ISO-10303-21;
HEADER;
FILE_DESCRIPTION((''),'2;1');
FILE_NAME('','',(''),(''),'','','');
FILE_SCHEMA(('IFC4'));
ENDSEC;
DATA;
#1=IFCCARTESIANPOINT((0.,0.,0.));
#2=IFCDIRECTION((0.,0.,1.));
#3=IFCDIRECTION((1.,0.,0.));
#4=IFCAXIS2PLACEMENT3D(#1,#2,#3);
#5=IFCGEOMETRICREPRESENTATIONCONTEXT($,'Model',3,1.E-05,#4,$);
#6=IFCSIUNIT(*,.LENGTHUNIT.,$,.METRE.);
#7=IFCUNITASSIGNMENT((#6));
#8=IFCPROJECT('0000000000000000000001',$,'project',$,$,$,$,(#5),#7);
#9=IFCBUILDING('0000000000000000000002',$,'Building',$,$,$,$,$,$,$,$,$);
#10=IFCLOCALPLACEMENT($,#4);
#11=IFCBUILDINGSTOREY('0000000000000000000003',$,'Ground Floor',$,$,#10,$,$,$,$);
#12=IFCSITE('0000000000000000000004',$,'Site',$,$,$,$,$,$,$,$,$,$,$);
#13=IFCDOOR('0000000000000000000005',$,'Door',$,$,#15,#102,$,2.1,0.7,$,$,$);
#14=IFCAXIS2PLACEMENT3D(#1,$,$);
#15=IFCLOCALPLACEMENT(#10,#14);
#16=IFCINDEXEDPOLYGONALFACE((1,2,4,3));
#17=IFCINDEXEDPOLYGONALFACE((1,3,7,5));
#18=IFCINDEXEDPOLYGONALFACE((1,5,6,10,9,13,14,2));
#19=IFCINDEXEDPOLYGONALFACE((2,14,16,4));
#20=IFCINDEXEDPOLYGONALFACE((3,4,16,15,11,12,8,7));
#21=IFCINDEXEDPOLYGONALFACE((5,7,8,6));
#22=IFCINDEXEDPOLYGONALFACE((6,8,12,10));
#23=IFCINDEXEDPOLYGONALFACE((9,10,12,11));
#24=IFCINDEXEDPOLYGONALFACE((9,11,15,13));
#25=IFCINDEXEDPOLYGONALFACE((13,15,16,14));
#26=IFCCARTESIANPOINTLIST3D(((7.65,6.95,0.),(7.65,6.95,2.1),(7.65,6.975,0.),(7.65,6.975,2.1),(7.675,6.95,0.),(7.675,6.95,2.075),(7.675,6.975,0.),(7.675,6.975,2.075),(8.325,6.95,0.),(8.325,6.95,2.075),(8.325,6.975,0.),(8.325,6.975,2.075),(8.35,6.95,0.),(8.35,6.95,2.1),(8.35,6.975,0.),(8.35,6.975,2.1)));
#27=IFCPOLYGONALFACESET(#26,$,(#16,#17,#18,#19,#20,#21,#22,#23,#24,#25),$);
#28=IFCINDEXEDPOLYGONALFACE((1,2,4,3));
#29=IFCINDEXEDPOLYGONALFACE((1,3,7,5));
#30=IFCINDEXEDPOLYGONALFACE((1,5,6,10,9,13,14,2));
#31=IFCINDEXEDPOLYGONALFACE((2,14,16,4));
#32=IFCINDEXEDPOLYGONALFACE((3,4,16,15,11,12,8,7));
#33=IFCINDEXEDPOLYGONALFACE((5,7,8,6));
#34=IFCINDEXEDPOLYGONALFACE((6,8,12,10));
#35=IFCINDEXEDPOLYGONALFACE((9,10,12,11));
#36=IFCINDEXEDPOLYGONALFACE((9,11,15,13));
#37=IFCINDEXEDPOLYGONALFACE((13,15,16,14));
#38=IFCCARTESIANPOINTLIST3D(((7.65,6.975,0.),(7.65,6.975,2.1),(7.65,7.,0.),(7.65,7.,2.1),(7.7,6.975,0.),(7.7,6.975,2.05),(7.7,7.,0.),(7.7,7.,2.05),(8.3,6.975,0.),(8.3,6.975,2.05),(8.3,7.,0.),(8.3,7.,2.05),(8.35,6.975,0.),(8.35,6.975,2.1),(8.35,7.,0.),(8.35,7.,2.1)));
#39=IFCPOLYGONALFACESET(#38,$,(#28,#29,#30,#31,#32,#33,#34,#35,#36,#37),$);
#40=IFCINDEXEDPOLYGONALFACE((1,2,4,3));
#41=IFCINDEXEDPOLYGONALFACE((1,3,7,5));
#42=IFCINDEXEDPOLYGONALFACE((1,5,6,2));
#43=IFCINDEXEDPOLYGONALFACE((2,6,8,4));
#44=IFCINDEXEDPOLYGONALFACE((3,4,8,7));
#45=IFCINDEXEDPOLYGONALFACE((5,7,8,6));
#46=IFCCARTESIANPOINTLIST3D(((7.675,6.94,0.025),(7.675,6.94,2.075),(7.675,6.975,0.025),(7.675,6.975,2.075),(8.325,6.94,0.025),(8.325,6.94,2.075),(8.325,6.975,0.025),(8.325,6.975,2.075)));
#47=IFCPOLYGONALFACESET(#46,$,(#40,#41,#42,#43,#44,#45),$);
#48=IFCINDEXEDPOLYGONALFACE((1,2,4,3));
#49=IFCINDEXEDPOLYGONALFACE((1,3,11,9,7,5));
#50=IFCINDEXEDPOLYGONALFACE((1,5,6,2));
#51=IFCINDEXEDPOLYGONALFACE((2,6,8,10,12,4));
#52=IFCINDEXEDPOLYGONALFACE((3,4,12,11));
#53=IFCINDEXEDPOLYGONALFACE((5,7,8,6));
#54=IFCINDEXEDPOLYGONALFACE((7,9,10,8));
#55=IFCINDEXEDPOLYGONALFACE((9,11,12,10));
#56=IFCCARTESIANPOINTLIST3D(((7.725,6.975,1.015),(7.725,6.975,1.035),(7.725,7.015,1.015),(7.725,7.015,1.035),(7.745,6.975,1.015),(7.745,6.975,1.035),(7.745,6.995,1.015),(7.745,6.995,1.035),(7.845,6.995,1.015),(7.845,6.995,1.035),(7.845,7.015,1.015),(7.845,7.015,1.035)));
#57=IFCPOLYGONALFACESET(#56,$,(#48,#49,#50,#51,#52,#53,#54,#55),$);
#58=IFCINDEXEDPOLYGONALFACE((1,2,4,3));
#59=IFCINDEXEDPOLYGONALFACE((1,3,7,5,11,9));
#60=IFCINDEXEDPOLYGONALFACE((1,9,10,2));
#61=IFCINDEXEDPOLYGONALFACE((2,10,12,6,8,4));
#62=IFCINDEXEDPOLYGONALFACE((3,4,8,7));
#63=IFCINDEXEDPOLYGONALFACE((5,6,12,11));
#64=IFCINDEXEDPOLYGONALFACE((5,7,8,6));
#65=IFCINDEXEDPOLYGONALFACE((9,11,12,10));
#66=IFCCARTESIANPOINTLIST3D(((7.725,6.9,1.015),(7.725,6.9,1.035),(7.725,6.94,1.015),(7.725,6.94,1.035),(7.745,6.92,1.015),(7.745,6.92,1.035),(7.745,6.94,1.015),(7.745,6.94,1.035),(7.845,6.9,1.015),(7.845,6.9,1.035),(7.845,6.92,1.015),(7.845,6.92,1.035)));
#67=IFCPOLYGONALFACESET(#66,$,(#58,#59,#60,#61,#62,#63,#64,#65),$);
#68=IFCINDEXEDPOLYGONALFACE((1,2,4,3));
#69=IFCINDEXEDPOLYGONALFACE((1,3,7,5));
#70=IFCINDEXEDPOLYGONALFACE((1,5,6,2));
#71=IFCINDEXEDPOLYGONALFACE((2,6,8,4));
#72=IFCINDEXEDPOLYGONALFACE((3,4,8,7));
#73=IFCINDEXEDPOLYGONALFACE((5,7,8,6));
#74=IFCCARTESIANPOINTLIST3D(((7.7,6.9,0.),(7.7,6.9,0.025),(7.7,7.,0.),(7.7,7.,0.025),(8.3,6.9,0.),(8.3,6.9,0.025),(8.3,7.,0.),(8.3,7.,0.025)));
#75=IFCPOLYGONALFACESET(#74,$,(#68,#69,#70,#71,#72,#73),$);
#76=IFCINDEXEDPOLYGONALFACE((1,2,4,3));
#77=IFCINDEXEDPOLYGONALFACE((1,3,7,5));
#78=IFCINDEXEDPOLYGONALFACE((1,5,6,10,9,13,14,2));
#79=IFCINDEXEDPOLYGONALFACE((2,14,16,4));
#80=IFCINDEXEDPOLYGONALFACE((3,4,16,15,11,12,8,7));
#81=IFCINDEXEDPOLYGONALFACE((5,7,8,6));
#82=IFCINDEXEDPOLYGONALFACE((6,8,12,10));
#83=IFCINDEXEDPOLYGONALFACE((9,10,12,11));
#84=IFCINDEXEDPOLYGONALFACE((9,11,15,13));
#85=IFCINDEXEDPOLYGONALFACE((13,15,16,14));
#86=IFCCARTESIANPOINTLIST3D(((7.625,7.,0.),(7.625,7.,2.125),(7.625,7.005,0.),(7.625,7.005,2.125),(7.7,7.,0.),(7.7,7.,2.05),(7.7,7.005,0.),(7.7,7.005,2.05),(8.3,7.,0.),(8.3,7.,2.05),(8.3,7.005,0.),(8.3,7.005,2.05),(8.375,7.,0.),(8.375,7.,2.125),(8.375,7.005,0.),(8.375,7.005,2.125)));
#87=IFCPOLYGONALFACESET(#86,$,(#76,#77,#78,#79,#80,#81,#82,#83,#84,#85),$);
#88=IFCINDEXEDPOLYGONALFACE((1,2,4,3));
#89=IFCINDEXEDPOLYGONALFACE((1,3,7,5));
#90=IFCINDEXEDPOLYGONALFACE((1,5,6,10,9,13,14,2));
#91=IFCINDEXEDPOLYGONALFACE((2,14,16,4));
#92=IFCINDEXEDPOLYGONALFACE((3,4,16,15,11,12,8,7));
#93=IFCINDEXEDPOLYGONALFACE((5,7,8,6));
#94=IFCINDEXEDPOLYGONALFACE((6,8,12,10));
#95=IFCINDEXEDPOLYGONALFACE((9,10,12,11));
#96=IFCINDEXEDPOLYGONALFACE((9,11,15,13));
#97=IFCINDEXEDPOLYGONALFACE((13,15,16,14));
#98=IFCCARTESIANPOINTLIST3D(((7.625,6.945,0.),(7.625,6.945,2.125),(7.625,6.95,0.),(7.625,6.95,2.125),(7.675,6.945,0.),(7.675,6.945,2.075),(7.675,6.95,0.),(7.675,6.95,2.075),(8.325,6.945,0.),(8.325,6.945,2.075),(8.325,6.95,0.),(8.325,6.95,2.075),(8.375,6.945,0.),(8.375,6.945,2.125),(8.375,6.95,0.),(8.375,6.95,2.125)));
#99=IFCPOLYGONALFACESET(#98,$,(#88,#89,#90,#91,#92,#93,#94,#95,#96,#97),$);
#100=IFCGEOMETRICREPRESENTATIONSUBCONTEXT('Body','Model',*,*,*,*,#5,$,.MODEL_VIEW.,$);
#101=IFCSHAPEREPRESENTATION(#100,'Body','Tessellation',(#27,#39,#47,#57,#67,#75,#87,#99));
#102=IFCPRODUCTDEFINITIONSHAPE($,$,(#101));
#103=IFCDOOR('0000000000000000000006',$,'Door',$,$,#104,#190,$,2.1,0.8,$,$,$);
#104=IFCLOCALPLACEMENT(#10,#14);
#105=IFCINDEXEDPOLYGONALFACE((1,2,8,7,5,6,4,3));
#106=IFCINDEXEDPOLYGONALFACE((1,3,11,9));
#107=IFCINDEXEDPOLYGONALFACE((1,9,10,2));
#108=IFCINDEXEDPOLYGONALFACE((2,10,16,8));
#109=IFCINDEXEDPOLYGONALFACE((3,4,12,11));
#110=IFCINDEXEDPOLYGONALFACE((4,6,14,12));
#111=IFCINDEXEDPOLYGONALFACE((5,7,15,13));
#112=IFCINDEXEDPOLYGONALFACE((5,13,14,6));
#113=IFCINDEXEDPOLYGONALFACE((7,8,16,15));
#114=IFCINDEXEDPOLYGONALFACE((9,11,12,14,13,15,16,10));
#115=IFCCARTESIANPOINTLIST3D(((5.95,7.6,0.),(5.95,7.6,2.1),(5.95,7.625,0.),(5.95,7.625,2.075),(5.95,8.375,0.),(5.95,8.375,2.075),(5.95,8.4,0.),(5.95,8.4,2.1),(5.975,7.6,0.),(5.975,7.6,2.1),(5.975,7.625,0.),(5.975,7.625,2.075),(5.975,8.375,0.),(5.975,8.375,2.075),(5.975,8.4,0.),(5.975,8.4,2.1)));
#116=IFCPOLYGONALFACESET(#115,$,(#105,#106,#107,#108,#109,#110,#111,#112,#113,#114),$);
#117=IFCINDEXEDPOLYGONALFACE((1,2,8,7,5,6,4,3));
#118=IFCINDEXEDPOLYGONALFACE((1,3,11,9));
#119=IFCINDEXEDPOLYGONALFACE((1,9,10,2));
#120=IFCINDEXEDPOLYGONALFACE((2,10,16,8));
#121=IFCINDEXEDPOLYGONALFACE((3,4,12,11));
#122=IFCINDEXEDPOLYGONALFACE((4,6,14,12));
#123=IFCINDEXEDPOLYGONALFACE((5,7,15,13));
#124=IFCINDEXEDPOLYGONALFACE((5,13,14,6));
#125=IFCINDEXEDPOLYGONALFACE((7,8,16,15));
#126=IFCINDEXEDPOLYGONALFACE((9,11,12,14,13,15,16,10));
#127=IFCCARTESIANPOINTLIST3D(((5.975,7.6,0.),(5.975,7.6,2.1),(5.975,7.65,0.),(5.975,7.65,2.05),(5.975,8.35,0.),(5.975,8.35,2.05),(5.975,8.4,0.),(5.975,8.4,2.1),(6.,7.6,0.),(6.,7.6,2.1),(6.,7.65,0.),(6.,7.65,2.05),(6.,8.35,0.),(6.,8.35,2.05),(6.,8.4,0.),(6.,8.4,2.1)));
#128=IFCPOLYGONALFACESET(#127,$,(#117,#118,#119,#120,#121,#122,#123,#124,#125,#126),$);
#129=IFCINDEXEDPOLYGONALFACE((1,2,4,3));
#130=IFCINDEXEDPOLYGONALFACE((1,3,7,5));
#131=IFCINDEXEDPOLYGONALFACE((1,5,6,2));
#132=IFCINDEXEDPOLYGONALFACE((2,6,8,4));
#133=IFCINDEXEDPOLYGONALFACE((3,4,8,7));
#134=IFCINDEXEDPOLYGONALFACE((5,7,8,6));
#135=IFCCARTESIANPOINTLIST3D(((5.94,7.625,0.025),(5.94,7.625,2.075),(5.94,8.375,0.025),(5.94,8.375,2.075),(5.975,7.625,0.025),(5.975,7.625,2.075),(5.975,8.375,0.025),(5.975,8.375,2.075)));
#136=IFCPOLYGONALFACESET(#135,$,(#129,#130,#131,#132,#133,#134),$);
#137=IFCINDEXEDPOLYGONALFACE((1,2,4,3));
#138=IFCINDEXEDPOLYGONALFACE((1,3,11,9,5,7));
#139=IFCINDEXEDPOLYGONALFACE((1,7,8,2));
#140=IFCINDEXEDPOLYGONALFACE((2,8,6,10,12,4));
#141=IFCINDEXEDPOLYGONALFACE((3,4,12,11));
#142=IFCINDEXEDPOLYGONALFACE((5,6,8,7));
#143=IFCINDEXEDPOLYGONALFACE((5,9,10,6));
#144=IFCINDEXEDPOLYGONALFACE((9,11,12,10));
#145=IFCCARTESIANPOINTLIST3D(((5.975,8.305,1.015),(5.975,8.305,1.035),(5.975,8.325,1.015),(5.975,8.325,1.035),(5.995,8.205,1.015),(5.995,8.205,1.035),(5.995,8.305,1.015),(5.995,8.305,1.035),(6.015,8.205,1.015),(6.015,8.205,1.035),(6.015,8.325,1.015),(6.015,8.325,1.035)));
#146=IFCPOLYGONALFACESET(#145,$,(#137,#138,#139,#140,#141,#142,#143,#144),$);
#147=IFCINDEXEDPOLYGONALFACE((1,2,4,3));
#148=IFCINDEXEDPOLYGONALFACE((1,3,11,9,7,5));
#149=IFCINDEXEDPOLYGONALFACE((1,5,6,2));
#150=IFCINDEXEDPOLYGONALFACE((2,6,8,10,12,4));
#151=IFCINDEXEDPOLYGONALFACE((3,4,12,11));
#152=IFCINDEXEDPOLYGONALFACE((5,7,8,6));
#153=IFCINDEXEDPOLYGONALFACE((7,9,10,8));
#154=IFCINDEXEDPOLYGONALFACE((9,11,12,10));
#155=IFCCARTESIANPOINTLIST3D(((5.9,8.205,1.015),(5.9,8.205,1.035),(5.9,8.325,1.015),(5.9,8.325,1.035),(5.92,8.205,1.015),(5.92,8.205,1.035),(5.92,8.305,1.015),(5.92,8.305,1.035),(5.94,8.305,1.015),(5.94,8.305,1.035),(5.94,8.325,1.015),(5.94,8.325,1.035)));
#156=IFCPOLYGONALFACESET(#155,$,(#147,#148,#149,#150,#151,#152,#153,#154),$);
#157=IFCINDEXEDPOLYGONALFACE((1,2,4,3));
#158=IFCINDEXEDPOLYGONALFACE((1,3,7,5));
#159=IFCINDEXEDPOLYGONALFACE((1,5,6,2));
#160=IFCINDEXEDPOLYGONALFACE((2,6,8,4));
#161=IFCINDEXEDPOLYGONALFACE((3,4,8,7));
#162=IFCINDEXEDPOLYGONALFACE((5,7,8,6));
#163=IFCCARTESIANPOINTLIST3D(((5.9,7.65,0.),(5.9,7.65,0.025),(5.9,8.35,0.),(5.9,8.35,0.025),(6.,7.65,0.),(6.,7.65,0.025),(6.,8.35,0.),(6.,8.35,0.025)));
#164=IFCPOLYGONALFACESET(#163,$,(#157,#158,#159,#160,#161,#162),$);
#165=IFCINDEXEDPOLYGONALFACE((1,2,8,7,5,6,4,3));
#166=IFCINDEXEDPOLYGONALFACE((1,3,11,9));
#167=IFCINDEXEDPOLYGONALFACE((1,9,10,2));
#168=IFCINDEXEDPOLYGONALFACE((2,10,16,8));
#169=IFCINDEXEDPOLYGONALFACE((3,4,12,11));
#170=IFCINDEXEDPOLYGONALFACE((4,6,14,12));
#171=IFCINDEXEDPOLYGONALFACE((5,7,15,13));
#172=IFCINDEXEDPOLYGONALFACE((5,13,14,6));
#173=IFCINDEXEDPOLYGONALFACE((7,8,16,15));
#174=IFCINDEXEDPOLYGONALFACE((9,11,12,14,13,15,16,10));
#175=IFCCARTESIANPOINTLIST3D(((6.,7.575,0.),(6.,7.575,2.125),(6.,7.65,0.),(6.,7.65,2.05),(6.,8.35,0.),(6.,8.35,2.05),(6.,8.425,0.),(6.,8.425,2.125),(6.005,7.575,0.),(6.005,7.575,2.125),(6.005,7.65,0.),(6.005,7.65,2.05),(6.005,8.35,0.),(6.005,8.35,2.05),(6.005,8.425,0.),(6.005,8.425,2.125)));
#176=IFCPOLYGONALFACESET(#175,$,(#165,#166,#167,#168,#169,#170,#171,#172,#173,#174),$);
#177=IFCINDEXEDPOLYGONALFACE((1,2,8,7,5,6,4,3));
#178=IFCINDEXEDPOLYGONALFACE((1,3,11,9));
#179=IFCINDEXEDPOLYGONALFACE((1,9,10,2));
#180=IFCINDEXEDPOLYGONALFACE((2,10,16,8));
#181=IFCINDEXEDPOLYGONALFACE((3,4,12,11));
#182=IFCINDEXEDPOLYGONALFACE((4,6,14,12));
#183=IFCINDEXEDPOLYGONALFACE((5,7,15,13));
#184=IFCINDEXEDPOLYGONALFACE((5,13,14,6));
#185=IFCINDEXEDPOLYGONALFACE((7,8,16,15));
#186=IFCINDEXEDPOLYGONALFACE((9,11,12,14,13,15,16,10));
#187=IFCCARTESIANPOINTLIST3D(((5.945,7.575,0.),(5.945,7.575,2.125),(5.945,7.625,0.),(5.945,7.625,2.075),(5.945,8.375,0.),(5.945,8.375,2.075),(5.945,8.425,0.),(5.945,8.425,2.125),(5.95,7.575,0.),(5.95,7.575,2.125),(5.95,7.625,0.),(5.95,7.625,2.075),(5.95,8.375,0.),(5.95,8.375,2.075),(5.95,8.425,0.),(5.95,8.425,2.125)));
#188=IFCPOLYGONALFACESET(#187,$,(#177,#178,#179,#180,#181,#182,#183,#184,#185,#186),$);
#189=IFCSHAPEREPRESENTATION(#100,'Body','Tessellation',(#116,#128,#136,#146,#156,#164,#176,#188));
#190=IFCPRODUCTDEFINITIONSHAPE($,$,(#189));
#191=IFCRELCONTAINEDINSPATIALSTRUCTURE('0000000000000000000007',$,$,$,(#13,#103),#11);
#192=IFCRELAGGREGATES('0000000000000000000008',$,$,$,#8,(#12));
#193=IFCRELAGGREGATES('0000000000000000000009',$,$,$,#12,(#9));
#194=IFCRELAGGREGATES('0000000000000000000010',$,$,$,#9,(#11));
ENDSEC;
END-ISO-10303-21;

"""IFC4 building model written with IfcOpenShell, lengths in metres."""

from ifc_helpers import new_model, si_unit, frame, origin_with_axes, place, context, subcontext, project, spatial, line, indexed_curve, outline, extrude, element, save


model = new_model("IFC4")

# Units and contexts
model_context = context("Model", 3, precision=1e-05, world=origin_with_axes())
body_context = subcontext(model_context, "Body", "Model", "MODEL_VIEW")
ifc_project = project(units=[si_unit("LENGTHUNIT", "METRE")], contexts=[model_context])

# Site, building, storey
site = spatial("IfcSite", under=ifc_project, Name="Site")
building = spatial("IfcBuilding", under=site, Name="Building")
storey_placement = place(None, origin_with_axes())
storey = spatial("IfcBuildingStorey", under=building, at=storey_placement, Name="Ground Floor")

# Doors
door_1_placement = place(storey_placement, frame((8.35, 7.0, 0.0), z_axis=(0.0, 0.0, 1.0), x_axis=(-1.0, 0.0, 0.0)))
element("IfcDoor", 1, at=door_1_placement, inside=storey, Name="Door", OverallHeight=2.1, OverallWidth=0.7, context=body_context, shape_type="SweptSolid", body=[
    extrude(outline(indexed_curve([(0.0, 0.0), (0.0, 2.1), (0.7, 2.1), (0.7, 0.0), (0.675, 0.0), (0.675, 2.075), (0.025, 2.075), (0.025, 0.0)], segments=[line(1, 2, 3, 4, 5, 6, 7, 8, 1)])), frame((0.0, 0.025, 0.0), z_axis=(0.0, -1.0, 0.0), x_axis=(1.0, 0.0, 0.0)), (0.0, 0.0, -1.0), 0.025),
    extrude(outline(indexed_curve([(0.0, 0.0), (0.0, 2.1), (0.7, 2.1), (0.7, 0.0), (0.65, 0.0), (0.65, 2.05), (0.05, 2.05), (0.05, 0.0)], segments=[line(1, 2, 3, 4, 5, 6, 7, 8, 1)])), frame((0.0, 0.0, 0.0), z_axis=(0.0, -1.0, 0.0), x_axis=(1.0, 0.0, 0.0)), (0.0, 0.0, -1.0), 0.025),
    extrude(outline(indexed_curve([(0.0, 0.0), (0.65, 0.0), (0.65, 0.035), (0.0, 0.035)], segments=[line(1, 2, 3, 4, 1)])), frame((0.025, 0.025, 0.025), z_axis=(0.0, 0.0, 1.0), x_axis=(1.0, 0.0, 0.0)), (0.0, 0.0, 1.0), 2.05),
    extrude(outline(indexed_curve([(0.0, 0.0), (0.0, -0.04), (-0.12, -0.04), (-0.12, -0.02), (-0.02, -0.02), (-0.02, 0.0)], segments=[line(1, 2, 3, 4, 5, 6, 1)])), frame((0.625, 0.025, 1.015), z_axis=(0.0, 0.0, 1.0), x_axis=(1.0, 0.0, 0.0)), (0.0, 0.0, 1.0), 0.02),
    extrude(outline(indexed_curve([(0.0, 0.0), (0.0, 0.04), (-0.12, 0.04), (-0.12, 0.02), (-0.02, 0.02), (-0.02, 0.0)], segments=[line(1, 2, 3, 4, 5, 6, 1)])), frame((0.625, 0.06, 1.015), z_axis=(0.0, 0.0, 1.0), x_axis=(1.0, 0.0, 0.0)), (0.0, 0.0, 1.0), 0.02),
    extrude(outline(indexed_curve([(0.0, 0.0), (0.6, 0.0), (0.6, 0.1), (0.0, 0.1)], segments=[line(1, 2, 3, 4, 1)])), frame((0.05, 0.0, 0.0), z_axis=(0.0, 0.0, 1.0), x_axis=(1.0, 0.0, 0.0)), (0.0, 0.0, 1.0), 0.025),
    extrude(outline(indexed_curve([(0.0, 0.0), (0.0, 2.125), (0.75, 2.125), (0.75, 0.0), (0.675, 0.0), (0.675, 2.05), (0.075, 2.05), (0.075, 0.0)], segments=[line(1, 2, 3, 4, 5, 6, 7, 8, 1)])), frame((-0.025, -0.005, 0.0), z_axis=(0.0, -1.0, 0.0), x_axis=(1.0, 0.0, 0.0)), (0.0, 0.0, -1.0), 0.005),
    extrude(outline(indexed_curve([(0.0, 0.0), (0.0, 2.125), (0.75, 2.125), (0.75, 0.0), (0.7, 0.0), (0.7, 2.075), (0.05, 2.075), (0.05, 0.0)], segments=[line(1, 2, 3, 4, 5, 6, 7, 8, 1)])), frame((-0.025, 0.05, 0.0), z_axis=(0.0, -1.0, 0.0), x_axis=(1.0, 0.0, 0.0)), (0.0, 0.0, -1.0), 0.005),
])
door_2_placement = place(storey_placement, frame((6.0, 7.6, 0.0), z_axis=(0.0, 0.0, 1.0), x_axis=(0.0, 1.0, 0.0)))
element("IfcDoor", 2, at=door_2_placement, inside=storey, Name="Door", OverallHeight=2.1, OverallWidth=0.8, context=body_context, shape_type="SweptSolid", body=[
    extrude(outline(indexed_curve([(0.0, 0.0), (0.0, 2.1), (0.8, 2.1), (0.8, 0.0), (0.775, 0.0), (0.775, 2.075), (0.025, 2.075), (0.025, 0.0)], segments=[line(1, 2, 3, 4, 5, 6, 7, 8, 1)])), frame((0.0, 0.025, 0.0), z_axis=(0.0, -1.0, 0.0), x_axis=(1.0, 0.0, 0.0)), (0.0, 0.0, -1.0), 0.025),
    extrude(outline(indexed_curve([(0.0, 0.0), (0.0, 2.1), (0.8, 2.1), (0.8, 0.0), (0.75, 0.0), (0.75, 2.05), (0.05, 2.05), (0.05, 0.0)], segments=[line(1, 2, 3, 4, 5, 6, 7, 8, 1)])), frame((0.0, 0.0, 0.0), z_axis=(0.0, -1.0, 0.0), x_axis=(1.0, 0.0, 0.0)), (0.0, 0.0, -1.0), 0.025),
    extrude(outline(indexed_curve([(0.0, 0.0), (0.75, 0.0), (0.75, 0.035), (0.0, 0.035)], segments=[line(1, 2, 3, 4, 1)])), frame((0.025, 0.025, 0.025), z_axis=(0.0, 0.0, 1.0), x_axis=(1.0, 0.0, 0.0)), (0.0, 0.0, 1.0), 2.05),
    extrude(outline(indexed_curve([(0.0, 0.0), (0.0, -0.04), (-0.12, -0.04), (-0.12, -0.02), (-0.02, -0.02), (-0.02, 0.0)], segments=[line(1, 2, 3, 4, 5, 6, 1)])), frame((0.725, 0.025, 1.015), z_axis=(0.0, 0.0, 1.0), x_axis=(1.0, 0.0, 0.0)), (0.0, 0.0, 1.0), 0.02),
    extrude(outline(indexed_curve([(0.0, 0.0), (0.0, 0.04), (-0.12, 0.04), (-0.12, 0.02), (-0.02, 0.02), (-0.02, 0.0)], segments=[line(1, 2, 3, 4, 5, 6, 1)])), frame((0.725, 0.06, 1.015), z_axis=(0.0, 0.0, 1.0), x_axis=(1.0, 0.0, 0.0)), (0.0, 0.0, 1.0), 0.02),
    extrude(outline(indexed_curve([(0.0, 0.0), (0.7, 0.0), (0.7, 0.1), (0.0, 0.1)], segments=[line(1, 2, 3, 4, 1)])), frame((0.05, 0.0, 0.0), z_axis=(0.0, 0.0, 1.0), x_axis=(1.0, 0.0, 0.0)), (0.0, 0.0, 1.0), 0.025),
    extrude(outline(indexed_curve([(0.0, 0.0), (0.0, 2.125), (0.85, 2.125), (0.85, 0.0), (0.775, 0.0), (0.775, 2.05), (0.075, 2.05), (0.075, 0.0)], segments=[line(1, 2, 3, 4, 5, 6, 7, 8, 1)])), frame((-0.025, -0.005, 0.0), z_axis=(0.0, -1.0, 0.0), x_axis=(1.0, 0.0, 0.0)), (0.0, 0.0, -1.0), 0.005),
    extrude(outline(indexed_curve([(0.0, 0.0), (0.0, 2.125), (0.85, 2.125), (0.85, 0.0), (0.8, 0.0), (0.8, 2.075), (0.05, 2.075), (0.05, 0.0)], segments=[line(1, 2, 3, 4, 5, 6, 7, 8, 1)])), frame((-0.025, 0.05, 0.0), z_axis=(0.0, -1.0, 0.0), x_axis=(1.0, 0.0, 0.0)), (0.0, 0.0, -1.0), 0.005),
])

save(model, "model.ifc")
